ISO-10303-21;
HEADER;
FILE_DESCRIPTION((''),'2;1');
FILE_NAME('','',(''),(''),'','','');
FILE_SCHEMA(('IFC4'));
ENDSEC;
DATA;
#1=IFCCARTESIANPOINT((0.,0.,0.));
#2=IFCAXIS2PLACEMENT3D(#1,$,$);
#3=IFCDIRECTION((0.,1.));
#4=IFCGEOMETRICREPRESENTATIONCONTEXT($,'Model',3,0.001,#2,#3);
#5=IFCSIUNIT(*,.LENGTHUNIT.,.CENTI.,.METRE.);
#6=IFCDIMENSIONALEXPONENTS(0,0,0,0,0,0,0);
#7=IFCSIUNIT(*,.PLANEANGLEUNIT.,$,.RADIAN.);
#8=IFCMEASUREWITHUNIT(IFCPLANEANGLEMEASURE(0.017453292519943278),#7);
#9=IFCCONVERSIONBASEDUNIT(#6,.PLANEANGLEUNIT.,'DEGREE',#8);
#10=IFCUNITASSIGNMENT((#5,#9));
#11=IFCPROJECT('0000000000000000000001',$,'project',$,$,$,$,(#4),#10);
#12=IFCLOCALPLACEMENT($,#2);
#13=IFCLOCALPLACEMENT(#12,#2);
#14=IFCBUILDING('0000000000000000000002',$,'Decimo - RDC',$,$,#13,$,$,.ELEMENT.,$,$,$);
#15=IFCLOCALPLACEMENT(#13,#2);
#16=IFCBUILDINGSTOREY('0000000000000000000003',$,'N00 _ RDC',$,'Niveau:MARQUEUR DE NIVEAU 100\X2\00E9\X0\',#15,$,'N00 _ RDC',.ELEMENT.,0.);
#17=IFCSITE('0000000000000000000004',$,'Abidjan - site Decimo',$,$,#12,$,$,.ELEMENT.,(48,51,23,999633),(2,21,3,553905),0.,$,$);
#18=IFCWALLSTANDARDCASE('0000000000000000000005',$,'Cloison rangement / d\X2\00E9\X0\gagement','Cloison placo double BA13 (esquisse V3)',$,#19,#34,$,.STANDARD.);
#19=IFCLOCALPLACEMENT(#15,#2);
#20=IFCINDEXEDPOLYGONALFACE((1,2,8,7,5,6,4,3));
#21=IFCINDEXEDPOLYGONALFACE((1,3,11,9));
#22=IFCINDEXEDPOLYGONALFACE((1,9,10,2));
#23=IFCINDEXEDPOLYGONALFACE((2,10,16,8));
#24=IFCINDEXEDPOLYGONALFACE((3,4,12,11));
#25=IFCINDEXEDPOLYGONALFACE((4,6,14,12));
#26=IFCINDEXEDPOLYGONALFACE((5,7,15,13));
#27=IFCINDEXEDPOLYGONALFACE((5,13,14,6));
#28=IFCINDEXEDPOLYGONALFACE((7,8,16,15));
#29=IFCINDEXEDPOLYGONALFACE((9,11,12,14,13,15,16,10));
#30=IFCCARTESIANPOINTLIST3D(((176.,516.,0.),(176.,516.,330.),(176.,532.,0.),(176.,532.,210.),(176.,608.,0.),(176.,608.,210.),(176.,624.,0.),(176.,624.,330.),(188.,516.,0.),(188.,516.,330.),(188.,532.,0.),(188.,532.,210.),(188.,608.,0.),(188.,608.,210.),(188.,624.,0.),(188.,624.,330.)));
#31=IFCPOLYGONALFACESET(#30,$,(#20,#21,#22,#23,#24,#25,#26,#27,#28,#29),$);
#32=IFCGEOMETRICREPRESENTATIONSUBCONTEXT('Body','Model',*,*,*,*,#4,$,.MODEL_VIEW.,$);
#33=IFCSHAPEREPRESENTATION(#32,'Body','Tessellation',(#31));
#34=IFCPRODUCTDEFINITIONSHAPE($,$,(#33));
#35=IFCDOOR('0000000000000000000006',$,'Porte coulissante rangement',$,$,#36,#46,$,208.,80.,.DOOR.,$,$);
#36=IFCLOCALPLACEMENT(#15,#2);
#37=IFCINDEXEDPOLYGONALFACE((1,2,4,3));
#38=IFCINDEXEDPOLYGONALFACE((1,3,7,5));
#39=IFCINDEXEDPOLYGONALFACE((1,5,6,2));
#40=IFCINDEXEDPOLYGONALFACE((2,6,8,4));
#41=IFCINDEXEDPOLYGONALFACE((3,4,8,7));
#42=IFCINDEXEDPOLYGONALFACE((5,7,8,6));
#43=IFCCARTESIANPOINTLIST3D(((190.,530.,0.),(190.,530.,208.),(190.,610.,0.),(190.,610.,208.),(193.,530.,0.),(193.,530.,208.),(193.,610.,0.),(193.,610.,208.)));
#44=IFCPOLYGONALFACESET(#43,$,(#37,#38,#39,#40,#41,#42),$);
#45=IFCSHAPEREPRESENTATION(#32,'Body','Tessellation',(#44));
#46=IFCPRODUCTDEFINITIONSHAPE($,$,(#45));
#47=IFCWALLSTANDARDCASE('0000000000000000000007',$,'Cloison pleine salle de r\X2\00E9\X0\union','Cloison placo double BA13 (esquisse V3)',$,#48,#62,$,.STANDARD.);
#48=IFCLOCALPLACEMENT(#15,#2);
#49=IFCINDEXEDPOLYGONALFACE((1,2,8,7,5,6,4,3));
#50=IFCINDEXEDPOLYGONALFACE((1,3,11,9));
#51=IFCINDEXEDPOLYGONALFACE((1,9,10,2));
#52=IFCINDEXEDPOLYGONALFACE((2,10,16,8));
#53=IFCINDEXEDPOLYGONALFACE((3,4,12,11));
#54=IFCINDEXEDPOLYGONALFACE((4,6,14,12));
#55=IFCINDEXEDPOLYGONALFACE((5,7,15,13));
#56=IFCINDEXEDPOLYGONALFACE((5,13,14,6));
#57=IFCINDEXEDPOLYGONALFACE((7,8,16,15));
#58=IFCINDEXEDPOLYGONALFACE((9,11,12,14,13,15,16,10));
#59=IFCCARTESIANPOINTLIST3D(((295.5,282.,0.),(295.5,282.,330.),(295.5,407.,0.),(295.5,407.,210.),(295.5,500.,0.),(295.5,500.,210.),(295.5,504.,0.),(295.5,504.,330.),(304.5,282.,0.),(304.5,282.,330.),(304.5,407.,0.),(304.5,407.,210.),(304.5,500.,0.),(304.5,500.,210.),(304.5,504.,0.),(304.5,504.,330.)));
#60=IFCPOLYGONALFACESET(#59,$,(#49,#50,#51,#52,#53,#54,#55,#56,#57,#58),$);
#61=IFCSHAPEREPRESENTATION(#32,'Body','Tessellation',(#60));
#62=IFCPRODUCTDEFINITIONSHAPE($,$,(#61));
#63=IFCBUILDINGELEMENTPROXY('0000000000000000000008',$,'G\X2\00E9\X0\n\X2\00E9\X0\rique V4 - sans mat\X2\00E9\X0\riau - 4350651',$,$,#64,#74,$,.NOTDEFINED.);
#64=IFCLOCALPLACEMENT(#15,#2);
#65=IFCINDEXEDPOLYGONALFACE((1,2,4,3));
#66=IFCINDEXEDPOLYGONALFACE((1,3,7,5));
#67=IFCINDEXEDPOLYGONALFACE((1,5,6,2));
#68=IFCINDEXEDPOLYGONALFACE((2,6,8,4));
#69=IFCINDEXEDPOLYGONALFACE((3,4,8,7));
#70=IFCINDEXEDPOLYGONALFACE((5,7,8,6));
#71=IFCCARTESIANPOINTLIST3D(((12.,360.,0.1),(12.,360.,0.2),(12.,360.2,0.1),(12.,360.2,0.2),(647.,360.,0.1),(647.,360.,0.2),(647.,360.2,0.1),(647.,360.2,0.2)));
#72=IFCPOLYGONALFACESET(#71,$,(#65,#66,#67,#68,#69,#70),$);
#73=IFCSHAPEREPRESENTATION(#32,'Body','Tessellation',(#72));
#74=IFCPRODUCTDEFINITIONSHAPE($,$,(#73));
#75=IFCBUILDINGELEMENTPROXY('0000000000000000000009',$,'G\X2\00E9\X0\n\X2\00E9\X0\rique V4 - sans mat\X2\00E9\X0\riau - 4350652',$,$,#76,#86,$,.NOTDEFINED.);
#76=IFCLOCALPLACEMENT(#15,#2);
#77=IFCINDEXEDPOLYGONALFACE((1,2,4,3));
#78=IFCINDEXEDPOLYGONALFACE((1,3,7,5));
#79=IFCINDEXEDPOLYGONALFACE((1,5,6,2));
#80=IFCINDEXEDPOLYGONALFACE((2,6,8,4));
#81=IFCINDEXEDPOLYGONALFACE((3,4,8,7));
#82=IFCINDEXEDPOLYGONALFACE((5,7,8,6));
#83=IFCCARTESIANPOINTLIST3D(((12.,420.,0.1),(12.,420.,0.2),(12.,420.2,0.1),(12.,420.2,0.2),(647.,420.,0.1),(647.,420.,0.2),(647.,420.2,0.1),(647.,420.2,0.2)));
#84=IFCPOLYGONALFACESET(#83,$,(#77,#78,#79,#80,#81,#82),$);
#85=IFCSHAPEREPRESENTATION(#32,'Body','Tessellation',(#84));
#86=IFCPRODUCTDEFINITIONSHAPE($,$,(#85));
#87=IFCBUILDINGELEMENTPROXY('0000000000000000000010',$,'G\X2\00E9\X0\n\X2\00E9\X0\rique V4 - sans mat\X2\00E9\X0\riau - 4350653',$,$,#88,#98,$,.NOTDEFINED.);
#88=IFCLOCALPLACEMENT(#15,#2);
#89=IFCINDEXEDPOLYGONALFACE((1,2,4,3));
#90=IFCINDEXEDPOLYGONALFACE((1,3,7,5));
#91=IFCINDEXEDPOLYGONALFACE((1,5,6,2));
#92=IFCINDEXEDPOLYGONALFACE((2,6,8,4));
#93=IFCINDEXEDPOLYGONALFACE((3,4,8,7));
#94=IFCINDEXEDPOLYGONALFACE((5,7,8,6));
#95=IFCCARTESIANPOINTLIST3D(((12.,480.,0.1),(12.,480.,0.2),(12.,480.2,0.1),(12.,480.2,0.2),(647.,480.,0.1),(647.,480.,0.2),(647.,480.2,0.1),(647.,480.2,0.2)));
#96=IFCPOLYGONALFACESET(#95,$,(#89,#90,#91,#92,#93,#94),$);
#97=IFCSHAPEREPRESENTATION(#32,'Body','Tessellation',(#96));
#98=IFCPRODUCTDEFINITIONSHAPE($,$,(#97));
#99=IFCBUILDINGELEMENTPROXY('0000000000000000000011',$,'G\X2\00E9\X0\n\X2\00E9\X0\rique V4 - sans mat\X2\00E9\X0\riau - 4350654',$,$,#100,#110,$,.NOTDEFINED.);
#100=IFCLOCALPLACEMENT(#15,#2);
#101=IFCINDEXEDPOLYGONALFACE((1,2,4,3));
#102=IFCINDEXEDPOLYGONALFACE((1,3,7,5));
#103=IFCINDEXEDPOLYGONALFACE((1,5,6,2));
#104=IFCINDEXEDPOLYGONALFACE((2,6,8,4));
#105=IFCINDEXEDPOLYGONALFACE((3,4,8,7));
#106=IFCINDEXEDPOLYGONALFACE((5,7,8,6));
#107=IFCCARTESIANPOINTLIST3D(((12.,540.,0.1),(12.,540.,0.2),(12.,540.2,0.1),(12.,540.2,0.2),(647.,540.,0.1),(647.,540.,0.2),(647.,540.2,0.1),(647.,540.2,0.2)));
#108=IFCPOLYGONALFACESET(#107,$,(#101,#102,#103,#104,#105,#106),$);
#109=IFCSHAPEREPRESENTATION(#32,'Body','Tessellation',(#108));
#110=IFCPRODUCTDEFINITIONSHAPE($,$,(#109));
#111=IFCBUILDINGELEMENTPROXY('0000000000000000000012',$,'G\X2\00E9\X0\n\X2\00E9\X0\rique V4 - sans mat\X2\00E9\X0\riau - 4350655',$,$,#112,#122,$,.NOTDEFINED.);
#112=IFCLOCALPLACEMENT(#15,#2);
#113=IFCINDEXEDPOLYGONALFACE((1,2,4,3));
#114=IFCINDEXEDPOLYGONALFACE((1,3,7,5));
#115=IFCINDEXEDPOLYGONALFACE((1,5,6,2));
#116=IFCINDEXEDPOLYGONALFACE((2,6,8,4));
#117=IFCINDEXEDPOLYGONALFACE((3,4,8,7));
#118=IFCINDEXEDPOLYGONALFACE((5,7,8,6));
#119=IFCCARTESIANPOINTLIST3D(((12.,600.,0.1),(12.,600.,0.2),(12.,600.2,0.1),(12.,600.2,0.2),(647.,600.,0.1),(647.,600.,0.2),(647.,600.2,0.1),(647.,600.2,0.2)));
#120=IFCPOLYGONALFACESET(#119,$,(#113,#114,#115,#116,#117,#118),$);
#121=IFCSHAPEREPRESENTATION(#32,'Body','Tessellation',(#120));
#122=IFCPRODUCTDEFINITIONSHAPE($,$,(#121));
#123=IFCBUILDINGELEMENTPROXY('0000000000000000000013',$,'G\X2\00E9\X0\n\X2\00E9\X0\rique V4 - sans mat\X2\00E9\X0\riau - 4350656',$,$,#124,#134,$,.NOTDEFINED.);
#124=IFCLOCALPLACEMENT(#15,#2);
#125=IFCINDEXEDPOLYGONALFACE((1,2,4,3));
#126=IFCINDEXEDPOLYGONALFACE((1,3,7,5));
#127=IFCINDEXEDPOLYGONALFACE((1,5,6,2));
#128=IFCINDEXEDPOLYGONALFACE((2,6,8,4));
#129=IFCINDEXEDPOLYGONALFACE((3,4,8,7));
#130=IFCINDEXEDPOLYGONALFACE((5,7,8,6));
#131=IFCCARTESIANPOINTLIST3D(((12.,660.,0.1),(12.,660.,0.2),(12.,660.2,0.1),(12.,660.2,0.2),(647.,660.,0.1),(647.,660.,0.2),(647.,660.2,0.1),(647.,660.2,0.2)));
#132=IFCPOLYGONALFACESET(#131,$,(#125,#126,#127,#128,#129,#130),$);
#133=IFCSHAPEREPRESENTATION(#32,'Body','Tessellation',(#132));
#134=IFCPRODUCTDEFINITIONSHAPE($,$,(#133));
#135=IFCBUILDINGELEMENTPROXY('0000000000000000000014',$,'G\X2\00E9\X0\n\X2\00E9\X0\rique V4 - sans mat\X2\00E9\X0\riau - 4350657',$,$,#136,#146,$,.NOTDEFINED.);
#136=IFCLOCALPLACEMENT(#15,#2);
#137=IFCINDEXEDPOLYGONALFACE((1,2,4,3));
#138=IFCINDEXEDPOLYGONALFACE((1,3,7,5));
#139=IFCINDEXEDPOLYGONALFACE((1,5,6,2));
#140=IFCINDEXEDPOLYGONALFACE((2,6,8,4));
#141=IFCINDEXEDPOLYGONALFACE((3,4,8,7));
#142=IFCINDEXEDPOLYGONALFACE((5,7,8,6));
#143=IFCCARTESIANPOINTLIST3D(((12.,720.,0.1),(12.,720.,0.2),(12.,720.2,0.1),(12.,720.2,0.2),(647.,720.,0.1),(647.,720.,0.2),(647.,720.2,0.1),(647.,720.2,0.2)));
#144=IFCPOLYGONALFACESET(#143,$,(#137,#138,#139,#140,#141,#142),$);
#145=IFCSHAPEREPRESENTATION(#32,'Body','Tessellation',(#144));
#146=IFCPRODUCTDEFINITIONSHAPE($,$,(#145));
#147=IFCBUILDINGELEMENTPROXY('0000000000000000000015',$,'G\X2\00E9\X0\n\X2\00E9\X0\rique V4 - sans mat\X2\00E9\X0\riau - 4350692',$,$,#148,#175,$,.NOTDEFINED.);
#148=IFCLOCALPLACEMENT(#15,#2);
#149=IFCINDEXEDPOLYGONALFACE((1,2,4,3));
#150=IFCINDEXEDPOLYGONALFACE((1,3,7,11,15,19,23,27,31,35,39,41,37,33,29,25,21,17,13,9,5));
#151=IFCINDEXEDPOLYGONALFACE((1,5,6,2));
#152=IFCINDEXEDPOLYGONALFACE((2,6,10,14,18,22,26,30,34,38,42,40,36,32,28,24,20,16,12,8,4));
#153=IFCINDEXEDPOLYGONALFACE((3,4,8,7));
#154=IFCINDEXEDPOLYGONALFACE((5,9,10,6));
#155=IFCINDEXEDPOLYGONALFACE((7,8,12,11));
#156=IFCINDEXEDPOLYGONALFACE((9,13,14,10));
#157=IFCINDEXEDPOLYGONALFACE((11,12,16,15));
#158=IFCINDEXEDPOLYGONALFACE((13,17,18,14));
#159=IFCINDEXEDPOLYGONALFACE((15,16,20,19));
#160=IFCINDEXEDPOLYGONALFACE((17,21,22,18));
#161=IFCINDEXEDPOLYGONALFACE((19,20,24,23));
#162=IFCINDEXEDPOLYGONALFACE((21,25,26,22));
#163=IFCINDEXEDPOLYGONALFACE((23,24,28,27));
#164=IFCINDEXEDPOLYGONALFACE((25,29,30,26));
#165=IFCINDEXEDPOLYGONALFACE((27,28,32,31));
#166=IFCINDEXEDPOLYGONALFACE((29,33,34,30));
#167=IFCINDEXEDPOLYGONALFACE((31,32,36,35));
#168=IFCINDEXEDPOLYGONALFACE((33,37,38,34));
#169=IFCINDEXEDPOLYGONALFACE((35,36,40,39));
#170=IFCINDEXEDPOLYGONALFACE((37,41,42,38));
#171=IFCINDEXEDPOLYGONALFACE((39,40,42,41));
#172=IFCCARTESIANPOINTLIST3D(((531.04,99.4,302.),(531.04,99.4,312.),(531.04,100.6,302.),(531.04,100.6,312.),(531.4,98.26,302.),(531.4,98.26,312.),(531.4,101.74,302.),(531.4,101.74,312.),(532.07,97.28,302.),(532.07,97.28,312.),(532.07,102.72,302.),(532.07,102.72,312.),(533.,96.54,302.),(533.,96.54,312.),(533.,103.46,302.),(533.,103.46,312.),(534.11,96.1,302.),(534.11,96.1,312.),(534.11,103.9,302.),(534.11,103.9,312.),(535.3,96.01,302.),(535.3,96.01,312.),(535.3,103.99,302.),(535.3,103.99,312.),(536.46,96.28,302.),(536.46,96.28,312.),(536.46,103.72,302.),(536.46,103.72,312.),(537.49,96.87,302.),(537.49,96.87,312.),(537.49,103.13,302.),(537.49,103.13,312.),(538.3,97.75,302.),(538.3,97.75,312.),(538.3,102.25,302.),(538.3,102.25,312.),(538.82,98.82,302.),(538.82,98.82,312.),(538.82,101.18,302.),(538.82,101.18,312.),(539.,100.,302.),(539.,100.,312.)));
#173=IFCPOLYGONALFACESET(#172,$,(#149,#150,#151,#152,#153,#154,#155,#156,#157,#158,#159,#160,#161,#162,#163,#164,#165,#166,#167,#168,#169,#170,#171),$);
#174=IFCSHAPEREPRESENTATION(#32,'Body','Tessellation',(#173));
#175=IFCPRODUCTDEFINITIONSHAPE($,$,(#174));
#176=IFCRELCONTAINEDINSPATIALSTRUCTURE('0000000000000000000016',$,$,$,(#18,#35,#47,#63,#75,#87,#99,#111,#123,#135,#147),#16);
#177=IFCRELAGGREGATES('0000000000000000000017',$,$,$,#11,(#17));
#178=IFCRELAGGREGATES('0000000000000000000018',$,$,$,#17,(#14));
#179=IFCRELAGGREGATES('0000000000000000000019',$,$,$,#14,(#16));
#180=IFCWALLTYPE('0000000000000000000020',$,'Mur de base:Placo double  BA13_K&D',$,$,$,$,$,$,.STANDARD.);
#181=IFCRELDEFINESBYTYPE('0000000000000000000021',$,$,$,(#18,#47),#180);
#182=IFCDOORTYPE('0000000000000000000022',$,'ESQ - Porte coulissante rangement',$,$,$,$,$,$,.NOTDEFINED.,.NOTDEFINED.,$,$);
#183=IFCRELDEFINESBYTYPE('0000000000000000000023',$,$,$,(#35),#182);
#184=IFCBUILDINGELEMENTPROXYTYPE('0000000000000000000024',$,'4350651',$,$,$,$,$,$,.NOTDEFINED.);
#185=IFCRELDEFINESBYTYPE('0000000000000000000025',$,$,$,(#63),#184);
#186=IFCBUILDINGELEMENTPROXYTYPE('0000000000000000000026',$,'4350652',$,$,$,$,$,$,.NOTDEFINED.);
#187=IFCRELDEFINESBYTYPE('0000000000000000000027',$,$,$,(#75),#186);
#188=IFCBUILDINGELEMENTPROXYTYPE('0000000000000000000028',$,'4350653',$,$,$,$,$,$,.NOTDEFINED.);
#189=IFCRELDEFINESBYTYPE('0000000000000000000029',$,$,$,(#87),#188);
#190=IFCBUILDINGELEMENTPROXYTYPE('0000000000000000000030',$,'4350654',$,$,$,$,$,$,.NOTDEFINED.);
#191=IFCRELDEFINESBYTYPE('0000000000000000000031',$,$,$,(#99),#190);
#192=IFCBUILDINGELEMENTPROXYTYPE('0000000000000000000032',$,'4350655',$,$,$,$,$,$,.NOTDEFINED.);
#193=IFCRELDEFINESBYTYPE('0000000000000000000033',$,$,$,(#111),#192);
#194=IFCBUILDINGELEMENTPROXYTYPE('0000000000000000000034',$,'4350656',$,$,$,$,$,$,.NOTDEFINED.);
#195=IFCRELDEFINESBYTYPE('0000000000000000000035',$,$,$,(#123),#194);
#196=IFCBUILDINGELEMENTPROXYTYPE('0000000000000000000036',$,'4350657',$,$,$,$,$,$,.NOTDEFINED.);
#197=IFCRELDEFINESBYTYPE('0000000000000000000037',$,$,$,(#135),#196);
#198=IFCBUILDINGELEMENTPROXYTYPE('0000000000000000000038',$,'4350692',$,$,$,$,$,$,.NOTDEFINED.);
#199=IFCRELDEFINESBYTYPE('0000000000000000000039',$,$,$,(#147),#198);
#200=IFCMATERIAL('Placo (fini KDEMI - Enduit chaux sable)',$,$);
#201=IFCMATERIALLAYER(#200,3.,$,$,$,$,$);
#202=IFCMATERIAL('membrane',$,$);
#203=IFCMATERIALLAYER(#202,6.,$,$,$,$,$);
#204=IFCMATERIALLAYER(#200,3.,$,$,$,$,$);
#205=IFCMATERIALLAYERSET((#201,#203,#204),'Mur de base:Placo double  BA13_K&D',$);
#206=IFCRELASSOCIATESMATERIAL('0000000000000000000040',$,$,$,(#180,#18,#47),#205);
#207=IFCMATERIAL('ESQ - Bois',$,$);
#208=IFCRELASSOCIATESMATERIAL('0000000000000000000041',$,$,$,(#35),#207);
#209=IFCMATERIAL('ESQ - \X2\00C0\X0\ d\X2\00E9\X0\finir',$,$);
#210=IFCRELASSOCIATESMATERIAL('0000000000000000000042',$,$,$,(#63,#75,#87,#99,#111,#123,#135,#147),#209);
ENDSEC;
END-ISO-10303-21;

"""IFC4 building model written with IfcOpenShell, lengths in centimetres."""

from ifc_helpers import new_model, entity, si_unit, converted_unit, direction, frame, frame_2d, origin, origin_with_axes, origin_2d_with_axis, place, context, subcontext, project, spatial, rectangle, circle, extrude, material, layer, layer_set, layer_usage, type_object, element, fill, save


model = new_model("IFC4")

# Units and contexts
model_context = context("Model", 3, precision=0.001, world=origin(), true_north=direction((0.0, 1.0)))
body_context = subcontext(model_context, "Body", "Model", "MODEL_VIEW")
ifc_project = project(units=[si_unit("LENGTHUNIT", "METRE", prefix="CENTI"), converted_unit("PLANEANGLEUNIT", "DEGREE", entity("IfcPlaneAngleMeasure", 0.017453292519943278), si_unit("PLANEANGLEUNIT", "RADIAN"), dimensions=[0, 0, 0, 0, 0, 0, 0])], contexts=[model_context])

# Site, building, storey
site_placement = place(None, origin())
site = spatial("IfcSite", under=ifc_project, at=site_placement, Name="Abidjan - site Decimo", CompositionType="ELEMENT", RefLatitude=(48, 51, 23, 999633), RefLongitude=(2, 21, 3, 553905), RefElevation=0.0)
building_placement = place(site_placement, origin())
building = spatial("IfcBuilding", under=site, at=building_placement, Name="Decimo - RDC", CompositionType="ELEMENT")
storey_placement = place(building_placement, origin())
storey = spatial("IfcBuildingStorey", under=building, at=storey_placement, Name="N00 _ RDC", ObjectType="Niveau:MARQUEUR DE NIVEAU 100é", LongName="N00 _ RDC", CompositionType="ELEMENT", Elevation=0.0)

# Wall, opening, door
ifc_material_1 = material(Name="Placo (fini KDEMI - Enduit chaux sable)")
ifc_layer_1 = layer(ifc_material_1, 3.0)
ifc_material_2 = material(Name="membrane")
ifc_layer_2 = layer(ifc_material_2, 6.0)
ifc_layer_3 = layer(ifc_material_1, 3.0)
ifc_layer_set = layer_set([ifc_layer_1, ifc_layer_2, ifc_layer_3], Name="Mur de base:Placo double  BA13_K&D")
ifc_layer_usage_1 = layer_usage(ifc_layer_set, "AXIS2", "POSITIVE", 0.0)
wall_type = type_object("IfcWallType", Name="Mur de base:Placo double  BA13_K&D", PredefinedType="STANDARD", material=ifc_layer_set)
wall_1_placement = place(storey_placement, origin_with_axes())
wall_1 = element("IfcWallStandardCase", 1, at=wall_1_placement, inside=storey, type_object=wall_type, material=ifc_layer_usage_1, Name="Cloison rangement / dégagement", Description="Cloison placo double BA13 (esquisse V3)", PredefinedType="STANDARD", context=body_context, shape_type="SweptSolid", body=[
    extrude(rectangle(XDim=12.0, YDim=108.0, at=frame_2d((182.0, 570.0))), origin(), (0.0, 0.0, 1.0), 330.0),
])
opening_1_placement = place(wall_1_placement, origin_with_axes())
opening_1 = element("IfcOpeningElement", 2, at=opening_1_placement, inside=storey, cuts=wall_1, context=body_context, shape_type="SweptSolid", body=[
    extrude(rectangle(XDim=16.0, YDim=76.0, at=frame_2d((182.0, 570.0))), origin(), (0.0, 0.0, 1.0), 210.0),
])
ifc_material_3 = material(Name="ESQ - Bois")
door_type = type_object("IfcDoorType", Name="ESQ - Porte coulissante rangement", OperationType="NOTDEFINED", PredefinedType="NOTDEFINED")
door_placement = place(storey_placement, origin_with_axes())
door = element("IfcDoor", 3, at=door_placement, inside=storey, type_object=door_type, material=ifc_material_3, Name="Porte coulissante rangement", OverallHeight=208.0, OverallWidth=80.0, PredefinedType="DOOR", context=body_context, shape_type="SweptSolid", body=[
    extrude(rectangle(XDim=3.0, YDim=80.0, at=frame_2d((191.5, 570.0))), origin(), (0.0, 0.0, 1.0), 208.0),
])
fill(opening_1, door)

# Wall, opening
ifc_layer_usage_2 = layer_usage(ifc_layer_set, "AXIS2", "POSITIVE", 0.0)
wall_2_placement = place(storey_placement, origin_with_axes())
wall_2 = element("IfcWallStandardCase", 4, at=wall_2_placement, inside=storey, type_object=wall_type, material=ifc_layer_usage_2, Name="Cloison pleine salle de réunion", Description="Cloison placo double BA13 (esquisse V3)", PredefinedType="STANDARD", context=body_context, shape_type="SweptSolid", body=[
    extrude(rectangle(XDim=9.0, YDim=222.0, at=frame_2d((300.0, 393.0))), origin(), (0.0, 0.0, 1.0), 330.0),
])
opening_2_placement = place(wall_2_placement, origin_with_axes())
element("IfcOpeningElement", 5, at=opening_2_placement, inside=storey, cuts=wall_2, context=body_context, shape_type="SweptSolid", body=[
    extrude(rectangle(XDim=12.0, YDim=93.0, at=frame_2d((300.0, 453.5))), origin(), (0.0, 0.0, 1.0), 210.0),
])

# Building element proxies
ifc_material_4 = material(Name="ESQ - À définir")
building_element_proxy_type_1 = type_object("IfcBuildingElementProxyType", Name="4350651", PredefinedType="NOTDEFINED")
proxy_1_placement = place(storey_placement, origin())
element("IfcBuildingElementProxy", 6, at=proxy_1_placement, inside=storey, type_object=building_element_proxy_type_1, material=ifc_material_4, Name="Générique V4 - sans matériau - 4350651", PredefinedType="NOTDEFINED", context=body_context, shape_type="SweptSolid", body=[
    extrude(rectangle(XDim=635.0, YDim=0.2, at=frame_2d((0.0, 0.0), x_axis=(1.0, 0.0))), frame((329.5, 360.1, 0.1)), (0.0, 0.0, 1.0), 0.1),
])
building_element_proxy_type_2 = type_object("IfcBuildingElementProxyType", Name="4350652", PredefinedType="NOTDEFINED")
proxy_2_placement = place(storey_placement, origin())
element("IfcBuildingElementProxy", 7, at=proxy_2_placement, inside=storey, type_object=building_element_proxy_type_2, material=ifc_material_4, Name="Générique V4 - sans matériau - 4350652", PredefinedType="NOTDEFINED", context=body_context, shape_type="SweptSolid", body=[
    extrude(rectangle(XDim=635.0, YDim=0.2, at=frame_2d((0.0, 0.0), x_axis=(1.0, 0.0))), frame((329.5, 420.1, 0.1)), (0.0, 0.0, 1.0), 0.1),
])
building_element_proxy_type_3 = type_object("IfcBuildingElementProxyType", Name="4350653", PredefinedType="NOTDEFINED")
proxy_3_placement = place(storey_placement, origin())
element("IfcBuildingElementProxy", 8, at=proxy_3_placement, inside=storey, type_object=building_element_proxy_type_3, material=ifc_material_4, Name="Générique V4 - sans matériau - 4350653", PredefinedType="NOTDEFINED", context=body_context, shape_type="SweptSolid", body=[
    extrude(rectangle(XDim=635.0, YDim=0.2, at=frame_2d((0.0, 0.0), x_axis=(1.0, 0.0))), frame((329.5, 480.1, 0.1)), (0.0, 0.0, 1.0), 0.1),
])
building_element_proxy_type_4 = type_object("IfcBuildingElementProxyType", Name="4350654", PredefinedType="NOTDEFINED")
proxy_4_placement = place(storey_placement, origin())
element("IfcBuildingElementProxy", 9, at=proxy_4_placement, inside=storey, type_object=building_element_proxy_type_4, material=ifc_material_4, Name="Générique V4 - sans matériau - 4350654", PredefinedType="NOTDEFINED", context=body_context, shape_type="SweptSolid", body=[
    extrude(rectangle(XDim=635.0, YDim=0.2, at=frame_2d((0.0, 0.0), x_axis=(1.0, 0.0))), frame((329.5, 540.1, 0.1)), (0.0, 0.0, 1.0), 0.1),
])
building_element_proxy_type_5 = type_object("IfcBuildingElementProxyType", Name="4350655", PredefinedType="NOTDEFINED")
proxy_5_placement = place(storey_placement, origin())
element("IfcBuildingElementProxy", 10, at=proxy_5_placement, inside=storey, type_object=building_element_proxy_type_5, material=ifc_material_4, Name="Générique V4 - sans matériau - 4350655", PredefinedType="NOTDEFINED", context=body_context, shape_type="SweptSolid", body=[
    extrude(rectangle(XDim=635.0, YDim=0.2, at=frame_2d((0.0, 0.0), x_axis=(1.0, 0.0))), frame((329.5, 600.1, 0.1)), (0.0, 0.0, 1.0), 0.1),
])
building_element_proxy_type_6 = type_object("IfcBuildingElementProxyType", Name="4350656", PredefinedType="NOTDEFINED")
proxy_6_placement = place(storey_placement, origin())
element("IfcBuildingElementProxy", 11, at=proxy_6_placement, inside=storey, type_object=building_element_proxy_type_6, material=ifc_material_4, Name="Générique V4 - sans matériau - 4350656", PredefinedType="NOTDEFINED", context=body_context, shape_type="SweptSolid", body=[
    extrude(rectangle(XDim=635.0, YDim=0.2, at=frame_2d((0.0, 0.0), x_axis=(1.0, 0.0))), frame((329.5, 660.1, 0.1)), (0.0, 0.0, 1.0), 0.1),
])
building_element_proxy_type_7 = type_object("IfcBuildingElementProxyType", Name="4350657", PredefinedType="NOTDEFINED")
proxy_7_placement = place(storey_placement, origin())
element("IfcBuildingElementProxy", 12, at=proxy_7_placement, inside=storey, type_object=building_element_proxy_type_7, material=ifc_material_4, Name="Générique V4 - sans matériau - 4350657", PredefinedType="NOTDEFINED", context=body_context, shape_type="SweptSolid", body=[
    extrude(rectangle(XDim=635.0, YDim=0.2, at=frame_2d((0.0, 0.0), x_axis=(1.0, 0.0))), frame((329.5, 720.1, 0.1)), (0.0, 0.0, 1.0), 0.1),
])
building_element_proxy_type_8 = type_object("IfcBuildingElementProxyType", Name="4350692", PredefinedType="NOTDEFINED")
proxy_8_placement = place(storey_placement, origin())
element("IfcBuildingElementProxy", 13, at=proxy_8_placement, inside=storey, type_object=building_element_proxy_type_8, material=ifc_material_4, Name="Générique V4 - sans matériau - 4350692", PredefinedType="NOTDEFINED", context=body_context, shape_type="SweptSolid", body=[
    extrude(circle(Radius=4.0, at=origin_2d_with_axis()), frame((535.0, 100.0, 302.0)), (0.0, 0.0, 1.0), 10.0),
])

save(model, "model.ifc")
